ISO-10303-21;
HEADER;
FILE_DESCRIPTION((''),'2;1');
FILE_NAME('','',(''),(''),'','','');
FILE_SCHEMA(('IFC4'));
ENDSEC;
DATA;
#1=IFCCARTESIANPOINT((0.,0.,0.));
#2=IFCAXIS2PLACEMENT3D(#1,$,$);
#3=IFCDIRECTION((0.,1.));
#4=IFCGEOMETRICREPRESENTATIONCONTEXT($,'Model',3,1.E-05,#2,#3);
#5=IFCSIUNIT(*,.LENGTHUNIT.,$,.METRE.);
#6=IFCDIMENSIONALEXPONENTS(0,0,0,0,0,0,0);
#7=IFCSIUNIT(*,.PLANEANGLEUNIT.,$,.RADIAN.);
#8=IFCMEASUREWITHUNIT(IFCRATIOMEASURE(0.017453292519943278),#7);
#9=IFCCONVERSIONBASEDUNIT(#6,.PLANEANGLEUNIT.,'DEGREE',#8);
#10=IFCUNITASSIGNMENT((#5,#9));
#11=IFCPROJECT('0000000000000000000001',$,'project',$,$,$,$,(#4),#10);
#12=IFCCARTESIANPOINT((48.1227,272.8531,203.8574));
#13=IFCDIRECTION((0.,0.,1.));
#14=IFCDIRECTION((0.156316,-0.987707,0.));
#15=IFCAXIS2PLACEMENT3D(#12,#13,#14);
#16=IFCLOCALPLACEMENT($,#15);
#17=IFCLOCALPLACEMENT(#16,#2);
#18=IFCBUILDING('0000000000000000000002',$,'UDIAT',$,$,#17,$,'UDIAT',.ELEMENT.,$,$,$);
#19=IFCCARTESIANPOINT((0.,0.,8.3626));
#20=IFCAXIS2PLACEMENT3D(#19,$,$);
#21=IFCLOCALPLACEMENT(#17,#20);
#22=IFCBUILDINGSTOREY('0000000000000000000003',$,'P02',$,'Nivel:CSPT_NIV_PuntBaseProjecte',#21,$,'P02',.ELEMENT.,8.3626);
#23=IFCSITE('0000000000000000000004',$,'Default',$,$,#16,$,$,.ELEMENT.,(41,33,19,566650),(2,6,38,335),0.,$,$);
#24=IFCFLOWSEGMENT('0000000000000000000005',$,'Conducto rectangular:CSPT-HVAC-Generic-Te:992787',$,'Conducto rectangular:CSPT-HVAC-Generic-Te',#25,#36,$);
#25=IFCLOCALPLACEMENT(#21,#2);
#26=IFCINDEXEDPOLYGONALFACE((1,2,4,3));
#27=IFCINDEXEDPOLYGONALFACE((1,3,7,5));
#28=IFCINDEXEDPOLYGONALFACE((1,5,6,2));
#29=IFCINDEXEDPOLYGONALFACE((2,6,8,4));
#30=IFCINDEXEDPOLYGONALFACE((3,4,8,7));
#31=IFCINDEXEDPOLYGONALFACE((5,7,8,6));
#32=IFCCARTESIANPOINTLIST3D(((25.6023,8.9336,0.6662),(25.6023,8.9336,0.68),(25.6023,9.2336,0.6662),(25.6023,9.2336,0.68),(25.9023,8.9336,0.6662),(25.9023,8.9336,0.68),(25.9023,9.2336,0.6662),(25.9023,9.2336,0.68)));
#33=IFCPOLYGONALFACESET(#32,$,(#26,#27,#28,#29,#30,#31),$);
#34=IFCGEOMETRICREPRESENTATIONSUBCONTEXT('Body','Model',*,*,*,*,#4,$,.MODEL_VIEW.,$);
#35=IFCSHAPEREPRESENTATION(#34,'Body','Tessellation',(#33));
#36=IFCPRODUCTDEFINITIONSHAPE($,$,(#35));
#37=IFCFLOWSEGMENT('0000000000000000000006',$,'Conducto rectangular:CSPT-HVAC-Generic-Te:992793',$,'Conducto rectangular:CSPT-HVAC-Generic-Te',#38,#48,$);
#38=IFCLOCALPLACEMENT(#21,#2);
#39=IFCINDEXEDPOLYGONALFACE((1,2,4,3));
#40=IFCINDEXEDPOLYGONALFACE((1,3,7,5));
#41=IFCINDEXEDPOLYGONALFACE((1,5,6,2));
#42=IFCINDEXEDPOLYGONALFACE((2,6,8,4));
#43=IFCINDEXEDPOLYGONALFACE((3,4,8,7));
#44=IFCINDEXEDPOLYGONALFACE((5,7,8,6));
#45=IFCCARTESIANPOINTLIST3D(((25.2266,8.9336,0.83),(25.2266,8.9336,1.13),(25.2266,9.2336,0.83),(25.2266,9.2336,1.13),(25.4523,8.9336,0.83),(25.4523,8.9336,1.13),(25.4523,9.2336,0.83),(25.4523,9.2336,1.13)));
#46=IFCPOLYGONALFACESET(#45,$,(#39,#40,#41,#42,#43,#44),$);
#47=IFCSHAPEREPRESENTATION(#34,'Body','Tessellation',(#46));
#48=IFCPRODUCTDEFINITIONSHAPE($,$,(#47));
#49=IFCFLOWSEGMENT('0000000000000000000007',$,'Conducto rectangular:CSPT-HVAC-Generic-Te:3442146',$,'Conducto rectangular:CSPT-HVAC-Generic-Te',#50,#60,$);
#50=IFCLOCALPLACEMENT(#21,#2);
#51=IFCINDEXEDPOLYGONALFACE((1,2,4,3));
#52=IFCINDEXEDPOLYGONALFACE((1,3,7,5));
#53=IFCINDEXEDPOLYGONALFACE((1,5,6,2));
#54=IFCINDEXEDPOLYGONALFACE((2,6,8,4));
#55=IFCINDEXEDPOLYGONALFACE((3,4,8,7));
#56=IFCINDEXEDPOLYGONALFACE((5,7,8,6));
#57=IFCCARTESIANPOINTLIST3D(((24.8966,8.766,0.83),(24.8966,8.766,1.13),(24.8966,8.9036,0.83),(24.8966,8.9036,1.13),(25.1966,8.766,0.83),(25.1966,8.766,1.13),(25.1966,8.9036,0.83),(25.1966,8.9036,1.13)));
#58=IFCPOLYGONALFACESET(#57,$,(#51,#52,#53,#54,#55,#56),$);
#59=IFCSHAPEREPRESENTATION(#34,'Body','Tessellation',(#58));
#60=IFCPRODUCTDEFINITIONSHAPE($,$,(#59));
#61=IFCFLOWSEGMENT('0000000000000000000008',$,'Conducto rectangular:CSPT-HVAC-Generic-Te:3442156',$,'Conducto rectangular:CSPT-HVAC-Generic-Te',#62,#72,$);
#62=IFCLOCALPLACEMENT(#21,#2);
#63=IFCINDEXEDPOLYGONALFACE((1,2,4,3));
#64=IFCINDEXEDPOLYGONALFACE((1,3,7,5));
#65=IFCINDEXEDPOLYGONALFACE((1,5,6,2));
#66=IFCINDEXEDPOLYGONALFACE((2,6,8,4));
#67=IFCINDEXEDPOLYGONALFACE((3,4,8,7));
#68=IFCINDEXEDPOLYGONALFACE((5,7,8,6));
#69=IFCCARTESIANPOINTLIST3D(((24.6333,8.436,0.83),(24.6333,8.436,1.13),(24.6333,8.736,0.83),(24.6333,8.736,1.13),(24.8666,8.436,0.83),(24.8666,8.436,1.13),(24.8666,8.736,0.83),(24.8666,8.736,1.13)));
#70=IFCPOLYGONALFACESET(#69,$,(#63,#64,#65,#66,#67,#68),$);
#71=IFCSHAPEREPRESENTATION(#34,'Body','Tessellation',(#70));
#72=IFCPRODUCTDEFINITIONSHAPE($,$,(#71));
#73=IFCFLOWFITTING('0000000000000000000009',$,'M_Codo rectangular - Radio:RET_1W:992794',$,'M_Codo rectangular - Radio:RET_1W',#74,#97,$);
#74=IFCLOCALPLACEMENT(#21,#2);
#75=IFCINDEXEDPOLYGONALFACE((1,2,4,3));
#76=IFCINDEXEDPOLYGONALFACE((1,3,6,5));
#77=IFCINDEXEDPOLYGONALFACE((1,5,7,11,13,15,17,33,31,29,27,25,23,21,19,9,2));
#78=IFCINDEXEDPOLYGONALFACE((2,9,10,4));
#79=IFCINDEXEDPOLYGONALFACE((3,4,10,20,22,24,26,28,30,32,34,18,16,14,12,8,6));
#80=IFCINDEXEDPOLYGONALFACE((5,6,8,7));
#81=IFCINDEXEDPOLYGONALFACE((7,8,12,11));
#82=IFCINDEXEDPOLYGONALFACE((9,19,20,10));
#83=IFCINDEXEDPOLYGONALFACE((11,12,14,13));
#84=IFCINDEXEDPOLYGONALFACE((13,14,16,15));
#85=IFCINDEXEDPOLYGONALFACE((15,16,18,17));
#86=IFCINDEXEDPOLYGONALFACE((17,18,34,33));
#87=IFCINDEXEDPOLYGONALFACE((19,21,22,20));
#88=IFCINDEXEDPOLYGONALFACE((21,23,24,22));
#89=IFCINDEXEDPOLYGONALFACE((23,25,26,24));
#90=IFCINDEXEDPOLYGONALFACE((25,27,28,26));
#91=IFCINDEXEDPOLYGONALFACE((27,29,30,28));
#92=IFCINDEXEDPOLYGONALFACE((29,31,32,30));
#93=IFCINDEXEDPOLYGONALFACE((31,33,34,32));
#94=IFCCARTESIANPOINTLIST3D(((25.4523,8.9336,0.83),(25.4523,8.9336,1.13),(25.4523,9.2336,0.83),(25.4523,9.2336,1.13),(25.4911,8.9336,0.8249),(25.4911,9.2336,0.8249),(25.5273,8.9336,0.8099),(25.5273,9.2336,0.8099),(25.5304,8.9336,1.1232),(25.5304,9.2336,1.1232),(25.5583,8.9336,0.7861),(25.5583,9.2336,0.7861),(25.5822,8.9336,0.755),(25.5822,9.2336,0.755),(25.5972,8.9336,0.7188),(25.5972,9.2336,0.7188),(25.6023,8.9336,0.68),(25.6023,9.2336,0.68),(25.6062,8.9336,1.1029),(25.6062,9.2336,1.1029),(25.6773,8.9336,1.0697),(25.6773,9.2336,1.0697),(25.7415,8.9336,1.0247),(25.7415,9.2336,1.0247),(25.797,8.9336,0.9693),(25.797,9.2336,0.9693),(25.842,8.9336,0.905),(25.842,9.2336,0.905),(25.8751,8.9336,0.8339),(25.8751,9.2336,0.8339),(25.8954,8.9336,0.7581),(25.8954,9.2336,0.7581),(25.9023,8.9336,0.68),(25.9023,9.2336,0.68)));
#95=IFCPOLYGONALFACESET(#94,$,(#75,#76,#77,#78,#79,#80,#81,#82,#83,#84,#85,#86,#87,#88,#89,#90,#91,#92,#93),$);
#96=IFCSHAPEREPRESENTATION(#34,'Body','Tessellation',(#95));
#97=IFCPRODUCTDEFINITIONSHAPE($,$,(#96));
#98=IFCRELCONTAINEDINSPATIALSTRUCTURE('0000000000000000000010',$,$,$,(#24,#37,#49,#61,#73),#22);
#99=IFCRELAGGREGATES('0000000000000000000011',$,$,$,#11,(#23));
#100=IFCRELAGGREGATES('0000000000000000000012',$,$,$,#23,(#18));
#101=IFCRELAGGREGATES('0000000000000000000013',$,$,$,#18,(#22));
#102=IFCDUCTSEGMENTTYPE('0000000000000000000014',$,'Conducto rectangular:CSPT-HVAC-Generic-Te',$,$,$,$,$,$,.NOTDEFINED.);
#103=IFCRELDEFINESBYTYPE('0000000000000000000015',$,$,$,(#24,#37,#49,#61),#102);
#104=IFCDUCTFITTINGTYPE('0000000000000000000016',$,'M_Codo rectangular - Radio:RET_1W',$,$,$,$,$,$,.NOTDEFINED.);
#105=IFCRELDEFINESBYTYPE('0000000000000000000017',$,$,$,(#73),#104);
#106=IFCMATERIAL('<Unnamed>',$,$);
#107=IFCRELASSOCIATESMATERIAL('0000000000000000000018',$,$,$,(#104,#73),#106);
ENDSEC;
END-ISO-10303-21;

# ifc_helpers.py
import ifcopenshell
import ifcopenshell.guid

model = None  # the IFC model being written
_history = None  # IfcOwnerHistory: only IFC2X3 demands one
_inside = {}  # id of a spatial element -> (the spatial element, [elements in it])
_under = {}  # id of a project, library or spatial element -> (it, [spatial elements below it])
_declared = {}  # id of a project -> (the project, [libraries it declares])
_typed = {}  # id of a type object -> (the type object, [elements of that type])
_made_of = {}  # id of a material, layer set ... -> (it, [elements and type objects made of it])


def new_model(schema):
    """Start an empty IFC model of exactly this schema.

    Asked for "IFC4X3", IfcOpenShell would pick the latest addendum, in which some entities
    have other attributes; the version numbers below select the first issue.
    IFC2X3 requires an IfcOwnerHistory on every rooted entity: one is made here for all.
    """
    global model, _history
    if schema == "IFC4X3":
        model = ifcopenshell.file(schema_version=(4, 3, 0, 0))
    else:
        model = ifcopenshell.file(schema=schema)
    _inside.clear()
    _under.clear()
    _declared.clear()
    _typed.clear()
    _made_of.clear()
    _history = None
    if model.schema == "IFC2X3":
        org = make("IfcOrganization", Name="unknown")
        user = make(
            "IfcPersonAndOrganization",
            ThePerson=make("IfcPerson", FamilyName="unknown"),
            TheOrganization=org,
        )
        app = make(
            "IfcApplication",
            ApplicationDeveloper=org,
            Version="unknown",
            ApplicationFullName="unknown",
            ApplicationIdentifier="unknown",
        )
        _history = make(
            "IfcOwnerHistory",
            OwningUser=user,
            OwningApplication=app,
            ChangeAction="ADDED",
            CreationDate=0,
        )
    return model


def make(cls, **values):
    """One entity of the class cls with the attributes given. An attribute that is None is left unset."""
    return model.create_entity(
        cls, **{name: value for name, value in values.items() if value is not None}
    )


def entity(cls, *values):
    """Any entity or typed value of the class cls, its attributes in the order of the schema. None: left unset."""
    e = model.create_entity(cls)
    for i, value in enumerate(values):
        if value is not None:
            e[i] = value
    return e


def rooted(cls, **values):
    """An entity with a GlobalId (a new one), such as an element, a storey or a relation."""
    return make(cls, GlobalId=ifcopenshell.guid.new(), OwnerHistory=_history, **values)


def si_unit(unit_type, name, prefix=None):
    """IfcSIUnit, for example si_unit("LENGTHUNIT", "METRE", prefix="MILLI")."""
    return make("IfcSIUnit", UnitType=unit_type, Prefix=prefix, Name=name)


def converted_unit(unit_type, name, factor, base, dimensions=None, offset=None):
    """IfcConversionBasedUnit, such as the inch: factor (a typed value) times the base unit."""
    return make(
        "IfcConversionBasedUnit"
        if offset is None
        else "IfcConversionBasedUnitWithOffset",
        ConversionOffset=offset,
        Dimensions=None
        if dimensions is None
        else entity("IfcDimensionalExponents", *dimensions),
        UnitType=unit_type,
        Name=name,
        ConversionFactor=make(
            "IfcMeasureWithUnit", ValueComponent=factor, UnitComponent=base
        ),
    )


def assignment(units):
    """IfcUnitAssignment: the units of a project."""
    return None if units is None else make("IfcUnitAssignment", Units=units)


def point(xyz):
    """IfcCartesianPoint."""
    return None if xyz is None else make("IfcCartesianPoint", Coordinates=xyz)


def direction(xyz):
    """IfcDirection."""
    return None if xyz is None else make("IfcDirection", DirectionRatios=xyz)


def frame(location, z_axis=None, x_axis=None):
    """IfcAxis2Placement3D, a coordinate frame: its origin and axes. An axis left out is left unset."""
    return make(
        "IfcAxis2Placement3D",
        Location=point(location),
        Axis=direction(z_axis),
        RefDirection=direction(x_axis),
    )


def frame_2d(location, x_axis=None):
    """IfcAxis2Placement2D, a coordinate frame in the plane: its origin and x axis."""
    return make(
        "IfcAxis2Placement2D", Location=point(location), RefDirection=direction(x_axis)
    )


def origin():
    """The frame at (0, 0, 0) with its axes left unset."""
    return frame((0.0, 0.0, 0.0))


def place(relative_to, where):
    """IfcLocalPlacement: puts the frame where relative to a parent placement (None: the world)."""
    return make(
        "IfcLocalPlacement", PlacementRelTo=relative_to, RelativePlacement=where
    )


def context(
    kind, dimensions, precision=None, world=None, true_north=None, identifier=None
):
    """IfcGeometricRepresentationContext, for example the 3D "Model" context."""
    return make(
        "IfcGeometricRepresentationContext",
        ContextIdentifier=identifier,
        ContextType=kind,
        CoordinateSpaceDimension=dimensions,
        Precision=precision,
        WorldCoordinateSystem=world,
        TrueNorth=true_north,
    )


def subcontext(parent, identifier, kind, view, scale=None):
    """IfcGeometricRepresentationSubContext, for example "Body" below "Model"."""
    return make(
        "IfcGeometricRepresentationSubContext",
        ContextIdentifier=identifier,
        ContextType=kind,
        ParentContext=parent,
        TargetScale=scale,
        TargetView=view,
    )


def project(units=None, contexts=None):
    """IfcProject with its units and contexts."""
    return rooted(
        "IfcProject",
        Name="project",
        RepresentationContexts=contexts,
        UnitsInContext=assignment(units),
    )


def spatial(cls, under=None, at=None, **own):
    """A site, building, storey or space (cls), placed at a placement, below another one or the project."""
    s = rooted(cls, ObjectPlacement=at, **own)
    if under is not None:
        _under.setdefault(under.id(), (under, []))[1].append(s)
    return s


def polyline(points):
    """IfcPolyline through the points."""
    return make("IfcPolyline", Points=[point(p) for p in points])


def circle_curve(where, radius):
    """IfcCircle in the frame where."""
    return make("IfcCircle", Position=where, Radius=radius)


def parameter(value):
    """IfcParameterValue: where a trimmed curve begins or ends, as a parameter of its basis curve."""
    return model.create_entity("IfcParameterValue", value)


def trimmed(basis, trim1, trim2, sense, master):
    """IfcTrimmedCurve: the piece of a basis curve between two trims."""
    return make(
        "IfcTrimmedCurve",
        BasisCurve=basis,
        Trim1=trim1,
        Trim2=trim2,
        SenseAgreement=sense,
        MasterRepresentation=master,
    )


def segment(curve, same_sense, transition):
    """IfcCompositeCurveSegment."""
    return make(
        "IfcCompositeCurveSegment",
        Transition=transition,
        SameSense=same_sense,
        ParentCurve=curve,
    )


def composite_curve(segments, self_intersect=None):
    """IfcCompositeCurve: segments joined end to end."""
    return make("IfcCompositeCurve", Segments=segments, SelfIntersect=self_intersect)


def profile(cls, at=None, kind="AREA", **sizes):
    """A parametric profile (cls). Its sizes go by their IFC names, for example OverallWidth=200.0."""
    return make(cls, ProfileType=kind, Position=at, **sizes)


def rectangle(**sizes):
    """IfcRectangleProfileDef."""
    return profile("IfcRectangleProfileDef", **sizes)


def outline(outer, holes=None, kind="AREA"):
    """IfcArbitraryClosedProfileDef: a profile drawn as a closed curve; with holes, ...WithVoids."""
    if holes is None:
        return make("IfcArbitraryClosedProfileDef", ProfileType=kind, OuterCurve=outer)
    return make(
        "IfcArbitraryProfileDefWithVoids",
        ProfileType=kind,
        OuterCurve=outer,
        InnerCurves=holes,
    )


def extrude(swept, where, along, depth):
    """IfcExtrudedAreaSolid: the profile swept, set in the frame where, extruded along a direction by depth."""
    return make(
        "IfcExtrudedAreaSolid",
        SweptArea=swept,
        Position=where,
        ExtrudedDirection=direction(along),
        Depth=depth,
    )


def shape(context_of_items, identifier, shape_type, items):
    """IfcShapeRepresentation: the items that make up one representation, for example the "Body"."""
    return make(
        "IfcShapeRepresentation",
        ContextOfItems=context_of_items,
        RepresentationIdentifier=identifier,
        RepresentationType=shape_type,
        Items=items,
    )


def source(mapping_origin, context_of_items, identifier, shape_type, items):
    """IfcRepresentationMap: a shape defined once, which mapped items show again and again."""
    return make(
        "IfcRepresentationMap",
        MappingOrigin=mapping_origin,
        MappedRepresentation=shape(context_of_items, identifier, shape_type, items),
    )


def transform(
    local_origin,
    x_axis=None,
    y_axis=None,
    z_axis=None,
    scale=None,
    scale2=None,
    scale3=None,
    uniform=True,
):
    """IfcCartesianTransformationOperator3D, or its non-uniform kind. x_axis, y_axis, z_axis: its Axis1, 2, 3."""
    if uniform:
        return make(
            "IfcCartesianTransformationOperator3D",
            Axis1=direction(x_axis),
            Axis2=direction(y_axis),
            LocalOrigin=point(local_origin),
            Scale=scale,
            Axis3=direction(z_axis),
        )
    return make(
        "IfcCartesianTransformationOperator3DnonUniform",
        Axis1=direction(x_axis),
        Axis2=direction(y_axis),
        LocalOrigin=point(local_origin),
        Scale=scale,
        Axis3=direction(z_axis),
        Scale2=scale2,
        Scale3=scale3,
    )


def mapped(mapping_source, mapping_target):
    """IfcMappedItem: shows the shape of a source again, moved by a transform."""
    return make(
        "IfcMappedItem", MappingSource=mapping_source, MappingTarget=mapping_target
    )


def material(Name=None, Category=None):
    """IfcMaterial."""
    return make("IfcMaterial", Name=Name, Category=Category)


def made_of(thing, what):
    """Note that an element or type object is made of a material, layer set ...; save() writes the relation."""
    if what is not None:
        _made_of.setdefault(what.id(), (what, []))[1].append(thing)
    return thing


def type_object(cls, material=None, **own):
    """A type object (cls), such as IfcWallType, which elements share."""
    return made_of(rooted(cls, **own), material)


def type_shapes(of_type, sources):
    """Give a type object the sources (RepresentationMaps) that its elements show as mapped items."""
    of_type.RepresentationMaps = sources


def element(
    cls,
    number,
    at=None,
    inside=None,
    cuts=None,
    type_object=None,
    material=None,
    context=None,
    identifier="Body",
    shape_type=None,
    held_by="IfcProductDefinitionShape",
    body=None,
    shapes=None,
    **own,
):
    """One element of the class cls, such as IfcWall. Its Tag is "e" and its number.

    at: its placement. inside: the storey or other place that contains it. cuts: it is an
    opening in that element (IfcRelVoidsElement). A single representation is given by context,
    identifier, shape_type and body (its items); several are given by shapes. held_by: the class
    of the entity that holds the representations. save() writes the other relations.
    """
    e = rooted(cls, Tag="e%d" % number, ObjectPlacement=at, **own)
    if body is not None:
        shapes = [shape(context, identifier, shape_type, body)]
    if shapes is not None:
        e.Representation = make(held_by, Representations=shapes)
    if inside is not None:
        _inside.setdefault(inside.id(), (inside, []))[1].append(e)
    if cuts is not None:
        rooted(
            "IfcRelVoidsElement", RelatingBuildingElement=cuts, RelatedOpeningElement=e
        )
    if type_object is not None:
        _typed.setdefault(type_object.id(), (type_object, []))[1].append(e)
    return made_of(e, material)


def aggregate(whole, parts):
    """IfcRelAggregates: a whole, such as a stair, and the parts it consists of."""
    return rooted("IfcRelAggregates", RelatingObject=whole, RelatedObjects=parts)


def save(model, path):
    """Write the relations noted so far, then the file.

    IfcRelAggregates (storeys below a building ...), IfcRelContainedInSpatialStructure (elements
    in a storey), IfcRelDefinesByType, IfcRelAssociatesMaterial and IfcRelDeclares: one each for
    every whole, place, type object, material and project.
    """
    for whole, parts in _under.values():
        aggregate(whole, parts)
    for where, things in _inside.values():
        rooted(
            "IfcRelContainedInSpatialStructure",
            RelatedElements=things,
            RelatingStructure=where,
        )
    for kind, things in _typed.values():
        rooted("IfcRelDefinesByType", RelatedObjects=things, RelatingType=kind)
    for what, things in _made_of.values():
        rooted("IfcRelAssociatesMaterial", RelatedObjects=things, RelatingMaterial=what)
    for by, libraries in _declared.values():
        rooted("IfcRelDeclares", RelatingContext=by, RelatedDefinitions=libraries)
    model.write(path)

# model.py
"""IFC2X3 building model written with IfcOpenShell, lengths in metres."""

from ifc_helpers import new_model, entity, si_unit, converted_unit, direction, frame, frame_2d, origin, place, context, subcontext, project, spatial, polyline, circle_curve, parameter, trimmed, segment, composite_curve, rectangle, outline, extrude, source, transform, mapped, material, type_object, type_shapes, element, save


model = new_model("IFC2X3")

# Units and contexts
model_context = context("Model", 3, precision=1e-05, world=origin(), true_north=direction((0.0, 1.0)))
body_context = subcontext(model_context, "Body", "Model", "MODEL_VIEW")
ifc_project = project(units=[si_unit("LENGTHUNIT", "METRE"), converted_unit("PLANEANGLEUNIT", "DEGREE", entity("IfcRatioMeasure", 0.017453292519943278), si_unit("PLANEANGLEUNIT", "RADIAN"), dimensions=[0, 0, 0, 0, 0, 0, 0])], contexts=[model_context])

# Site, building, storey
site_placement = place(None, frame((48.1227, 272.8531, 203.8574), z_axis=(0.0, 0.0, 1.0), x_axis=(0.156316, -0.987707, 0.0)))
site = spatial("IfcSite", under=ifc_project, at=site_placement, Name="Default", CompositionType="ELEMENT", RefLatitude=(41, 33, 19, 566650), RefLongitude=(2, 6, 38, 335), RefElevation=0.0)
building_placement = place(site_placement, origin())
building = spatial("IfcBuilding", under=site, at=building_placement, Name="UDIAT", LongName="UDIAT", CompositionType="ELEMENT")
storey_placement = place(building_placement, frame((0.0, 0.0, 8.3626)))
storey = spatial("IfcBuildingStorey", under=building, at=storey_placement, Name="P02", ObjectType="Nivel:CSPT_NIV_PuntBaseProjecte", LongName="P02", CompositionType="ELEMENT", Elevation=8.3626)

# Flow segments
duct_segment_type = type_object("IfcDuctSegmentType", Name="Conducto rectangular:CSPT-HVAC-Generic-Te", PredefinedType="NOTDEFINED")
flow_segment_1_placement = place(storey_placement, origin())
element("IfcFlowSegment", 1, at=flow_segment_1_placement, inside=storey, type_object=duct_segment_type, Name="Conducto rectangular:CSPT-HVAC-Generic-Te:992787", ObjectType="Conducto rectangular:CSPT-HVAC-Generic-Te", context=body_context, shape_type="SweptSolid", body=[
    extrude(rectangle(XDim=0.3, YDim=0.3, at=frame_2d((0.0, 0.0), x_axis=(1.0, 0.0))), frame((25.7523, 9.0836, 0.6662), z_axis=(0.0, 0.0, 1.0), x_axis=(0.0, 1.0, 0.0)), (0.0, 0.0, 1.0), 0.0138),
])
flow_segment_2_placement = place(storey_placement, origin())
element("IfcFlowSegment", 2, at=flow_segment_2_placement, inside=storey, type_object=duct_segment_type, Name="Conducto rectangular:CSPT-HVAC-Generic-Te:992793", ObjectType="Conducto rectangular:CSPT-HVAC-Generic-Te", context=body_context, shape_type="SweptSolid", body=[
    extrude(rectangle(XDim=0.2257, YDim=0.3, at=frame_2d((0.0, 0.0), x_axis=(1.0, 0.0))), frame((25.3394, 9.0836, 0.83), z_axis=(0.0, 0.0, 1.0), x_axis=(-1.0, 0.0, 0.0)), (0.0, 0.0, 1.0), 0.3),
])
flow_segment_3_placement = place(storey_placement, origin())
element("IfcFlowSegment", 3, at=flow_segment_3_placement, inside=storey, type_object=duct_segment_type, Name="Conducto rectangular:CSPT-HVAC-Generic-Te:3442146", ObjectType="Conducto rectangular:CSPT-HVAC-Generic-Te", context=body_context, shape_type="SweptSolid", body=[
    extrude(rectangle(XDim=0.1376, YDim=0.3, at=frame_2d((0.0, 0.0), x_axis=(1.0, 0.0))), frame((25.0466, 8.8348, 0.83), z_axis=(0.0, 0.0, 1.0), x_axis=(0.0, -1.0, 0.0)), (0.0, 0.0, 1.0), 0.3),
])
flow_segment_4_placement = place(storey_placement, origin())
element("IfcFlowSegment", 4, at=flow_segment_4_placement, inside=storey, type_object=duct_segment_type, Name="Conducto rectangular:CSPT-HVAC-Generic-Te:3442156", ObjectType="Conducto rectangular:CSPT-HVAC-Generic-Te", context=body_context, shape_type="SweptSolid", body=[
    extrude(rectangle(XDim=0.2333, YDim=0.3, at=frame_2d((0.0, 0.0), x_axis=(1.0, 0.0))), frame((24.7499, 8.586, 0.83), z_axis=(0.0, 0.0, 1.0), x_axis=(-1.0, 0.0, 0.0)), (0.0, 0.0, 1.0), 0.3),
])

# Flow fitting
ifc_material = material(Name="<Unnamed>")
duct_fitting_type_1 = type_object("IfcDuctFittingType", Name="M_Codo rectangular - Radio:RET_1W", PredefinedType="NOTDEFINED", material=ifc_material)
shared_shape_1 = source(origin(), body_context, "Body", "SweptSolid", [
    extrude(outline(composite_curve([segment(polyline([(-0.3, -0.15), (0.0, -0.15)]), True, "CONTINUOUS"), segment(trimmed(circle_curve(frame_2d((0.15, -0.15), x_axis=(0.0, 1.0)), 0.15), [parameter(0.0)], [parameter(90.0)], True, "PARAMETER"), False, "CONTINUOUS"), segment(polyline([(0.15, 0.0), (0.15, 0.3)]), True, "CONTINUOUS"), segment(trimmed(circle_curve(frame_2d((0.15, -0.15), x_axis=(0.0, 1.0)), 0.45), [parameter(0.0)], [parameter(90.0)], True, "PARAMETER"), True, "CONTINUOUS")], self_intersect=False)), frame((-0.15, 0.15, -0.15), z_axis=(0.0, 0.0, 1.0), x_axis=(-1.0, 0.0, 0.0)), (0.0, 0.0, 1.0), 0.3),
])
type_shapes(duct_fitting_type_1, [shared_shape_1])
flow_fitting_1_placement = place(storey_placement, frame((25.7523, 9.0836, 0.98), z_axis=(0.0, -1.0, 0.0), x_axis=(0.0, 0.0, 1.0)))
element("IfcFlowFitting", 5, at=flow_fitting_1_placement, inside=storey, type_object=duct_fitting_type_1, material=ifc_material, Name="M_Codo rectangular - Radio:RET_1W:992794", ObjectType="M_Codo rectangular - Radio:RET_1W", context=body_context, shape_type="MappedRepresentation", body=[
    mapped(shared_shape_1, transform((0.0, 0.0, 0.0), scale=1.0)),
])

save(model, "model.ifc")
